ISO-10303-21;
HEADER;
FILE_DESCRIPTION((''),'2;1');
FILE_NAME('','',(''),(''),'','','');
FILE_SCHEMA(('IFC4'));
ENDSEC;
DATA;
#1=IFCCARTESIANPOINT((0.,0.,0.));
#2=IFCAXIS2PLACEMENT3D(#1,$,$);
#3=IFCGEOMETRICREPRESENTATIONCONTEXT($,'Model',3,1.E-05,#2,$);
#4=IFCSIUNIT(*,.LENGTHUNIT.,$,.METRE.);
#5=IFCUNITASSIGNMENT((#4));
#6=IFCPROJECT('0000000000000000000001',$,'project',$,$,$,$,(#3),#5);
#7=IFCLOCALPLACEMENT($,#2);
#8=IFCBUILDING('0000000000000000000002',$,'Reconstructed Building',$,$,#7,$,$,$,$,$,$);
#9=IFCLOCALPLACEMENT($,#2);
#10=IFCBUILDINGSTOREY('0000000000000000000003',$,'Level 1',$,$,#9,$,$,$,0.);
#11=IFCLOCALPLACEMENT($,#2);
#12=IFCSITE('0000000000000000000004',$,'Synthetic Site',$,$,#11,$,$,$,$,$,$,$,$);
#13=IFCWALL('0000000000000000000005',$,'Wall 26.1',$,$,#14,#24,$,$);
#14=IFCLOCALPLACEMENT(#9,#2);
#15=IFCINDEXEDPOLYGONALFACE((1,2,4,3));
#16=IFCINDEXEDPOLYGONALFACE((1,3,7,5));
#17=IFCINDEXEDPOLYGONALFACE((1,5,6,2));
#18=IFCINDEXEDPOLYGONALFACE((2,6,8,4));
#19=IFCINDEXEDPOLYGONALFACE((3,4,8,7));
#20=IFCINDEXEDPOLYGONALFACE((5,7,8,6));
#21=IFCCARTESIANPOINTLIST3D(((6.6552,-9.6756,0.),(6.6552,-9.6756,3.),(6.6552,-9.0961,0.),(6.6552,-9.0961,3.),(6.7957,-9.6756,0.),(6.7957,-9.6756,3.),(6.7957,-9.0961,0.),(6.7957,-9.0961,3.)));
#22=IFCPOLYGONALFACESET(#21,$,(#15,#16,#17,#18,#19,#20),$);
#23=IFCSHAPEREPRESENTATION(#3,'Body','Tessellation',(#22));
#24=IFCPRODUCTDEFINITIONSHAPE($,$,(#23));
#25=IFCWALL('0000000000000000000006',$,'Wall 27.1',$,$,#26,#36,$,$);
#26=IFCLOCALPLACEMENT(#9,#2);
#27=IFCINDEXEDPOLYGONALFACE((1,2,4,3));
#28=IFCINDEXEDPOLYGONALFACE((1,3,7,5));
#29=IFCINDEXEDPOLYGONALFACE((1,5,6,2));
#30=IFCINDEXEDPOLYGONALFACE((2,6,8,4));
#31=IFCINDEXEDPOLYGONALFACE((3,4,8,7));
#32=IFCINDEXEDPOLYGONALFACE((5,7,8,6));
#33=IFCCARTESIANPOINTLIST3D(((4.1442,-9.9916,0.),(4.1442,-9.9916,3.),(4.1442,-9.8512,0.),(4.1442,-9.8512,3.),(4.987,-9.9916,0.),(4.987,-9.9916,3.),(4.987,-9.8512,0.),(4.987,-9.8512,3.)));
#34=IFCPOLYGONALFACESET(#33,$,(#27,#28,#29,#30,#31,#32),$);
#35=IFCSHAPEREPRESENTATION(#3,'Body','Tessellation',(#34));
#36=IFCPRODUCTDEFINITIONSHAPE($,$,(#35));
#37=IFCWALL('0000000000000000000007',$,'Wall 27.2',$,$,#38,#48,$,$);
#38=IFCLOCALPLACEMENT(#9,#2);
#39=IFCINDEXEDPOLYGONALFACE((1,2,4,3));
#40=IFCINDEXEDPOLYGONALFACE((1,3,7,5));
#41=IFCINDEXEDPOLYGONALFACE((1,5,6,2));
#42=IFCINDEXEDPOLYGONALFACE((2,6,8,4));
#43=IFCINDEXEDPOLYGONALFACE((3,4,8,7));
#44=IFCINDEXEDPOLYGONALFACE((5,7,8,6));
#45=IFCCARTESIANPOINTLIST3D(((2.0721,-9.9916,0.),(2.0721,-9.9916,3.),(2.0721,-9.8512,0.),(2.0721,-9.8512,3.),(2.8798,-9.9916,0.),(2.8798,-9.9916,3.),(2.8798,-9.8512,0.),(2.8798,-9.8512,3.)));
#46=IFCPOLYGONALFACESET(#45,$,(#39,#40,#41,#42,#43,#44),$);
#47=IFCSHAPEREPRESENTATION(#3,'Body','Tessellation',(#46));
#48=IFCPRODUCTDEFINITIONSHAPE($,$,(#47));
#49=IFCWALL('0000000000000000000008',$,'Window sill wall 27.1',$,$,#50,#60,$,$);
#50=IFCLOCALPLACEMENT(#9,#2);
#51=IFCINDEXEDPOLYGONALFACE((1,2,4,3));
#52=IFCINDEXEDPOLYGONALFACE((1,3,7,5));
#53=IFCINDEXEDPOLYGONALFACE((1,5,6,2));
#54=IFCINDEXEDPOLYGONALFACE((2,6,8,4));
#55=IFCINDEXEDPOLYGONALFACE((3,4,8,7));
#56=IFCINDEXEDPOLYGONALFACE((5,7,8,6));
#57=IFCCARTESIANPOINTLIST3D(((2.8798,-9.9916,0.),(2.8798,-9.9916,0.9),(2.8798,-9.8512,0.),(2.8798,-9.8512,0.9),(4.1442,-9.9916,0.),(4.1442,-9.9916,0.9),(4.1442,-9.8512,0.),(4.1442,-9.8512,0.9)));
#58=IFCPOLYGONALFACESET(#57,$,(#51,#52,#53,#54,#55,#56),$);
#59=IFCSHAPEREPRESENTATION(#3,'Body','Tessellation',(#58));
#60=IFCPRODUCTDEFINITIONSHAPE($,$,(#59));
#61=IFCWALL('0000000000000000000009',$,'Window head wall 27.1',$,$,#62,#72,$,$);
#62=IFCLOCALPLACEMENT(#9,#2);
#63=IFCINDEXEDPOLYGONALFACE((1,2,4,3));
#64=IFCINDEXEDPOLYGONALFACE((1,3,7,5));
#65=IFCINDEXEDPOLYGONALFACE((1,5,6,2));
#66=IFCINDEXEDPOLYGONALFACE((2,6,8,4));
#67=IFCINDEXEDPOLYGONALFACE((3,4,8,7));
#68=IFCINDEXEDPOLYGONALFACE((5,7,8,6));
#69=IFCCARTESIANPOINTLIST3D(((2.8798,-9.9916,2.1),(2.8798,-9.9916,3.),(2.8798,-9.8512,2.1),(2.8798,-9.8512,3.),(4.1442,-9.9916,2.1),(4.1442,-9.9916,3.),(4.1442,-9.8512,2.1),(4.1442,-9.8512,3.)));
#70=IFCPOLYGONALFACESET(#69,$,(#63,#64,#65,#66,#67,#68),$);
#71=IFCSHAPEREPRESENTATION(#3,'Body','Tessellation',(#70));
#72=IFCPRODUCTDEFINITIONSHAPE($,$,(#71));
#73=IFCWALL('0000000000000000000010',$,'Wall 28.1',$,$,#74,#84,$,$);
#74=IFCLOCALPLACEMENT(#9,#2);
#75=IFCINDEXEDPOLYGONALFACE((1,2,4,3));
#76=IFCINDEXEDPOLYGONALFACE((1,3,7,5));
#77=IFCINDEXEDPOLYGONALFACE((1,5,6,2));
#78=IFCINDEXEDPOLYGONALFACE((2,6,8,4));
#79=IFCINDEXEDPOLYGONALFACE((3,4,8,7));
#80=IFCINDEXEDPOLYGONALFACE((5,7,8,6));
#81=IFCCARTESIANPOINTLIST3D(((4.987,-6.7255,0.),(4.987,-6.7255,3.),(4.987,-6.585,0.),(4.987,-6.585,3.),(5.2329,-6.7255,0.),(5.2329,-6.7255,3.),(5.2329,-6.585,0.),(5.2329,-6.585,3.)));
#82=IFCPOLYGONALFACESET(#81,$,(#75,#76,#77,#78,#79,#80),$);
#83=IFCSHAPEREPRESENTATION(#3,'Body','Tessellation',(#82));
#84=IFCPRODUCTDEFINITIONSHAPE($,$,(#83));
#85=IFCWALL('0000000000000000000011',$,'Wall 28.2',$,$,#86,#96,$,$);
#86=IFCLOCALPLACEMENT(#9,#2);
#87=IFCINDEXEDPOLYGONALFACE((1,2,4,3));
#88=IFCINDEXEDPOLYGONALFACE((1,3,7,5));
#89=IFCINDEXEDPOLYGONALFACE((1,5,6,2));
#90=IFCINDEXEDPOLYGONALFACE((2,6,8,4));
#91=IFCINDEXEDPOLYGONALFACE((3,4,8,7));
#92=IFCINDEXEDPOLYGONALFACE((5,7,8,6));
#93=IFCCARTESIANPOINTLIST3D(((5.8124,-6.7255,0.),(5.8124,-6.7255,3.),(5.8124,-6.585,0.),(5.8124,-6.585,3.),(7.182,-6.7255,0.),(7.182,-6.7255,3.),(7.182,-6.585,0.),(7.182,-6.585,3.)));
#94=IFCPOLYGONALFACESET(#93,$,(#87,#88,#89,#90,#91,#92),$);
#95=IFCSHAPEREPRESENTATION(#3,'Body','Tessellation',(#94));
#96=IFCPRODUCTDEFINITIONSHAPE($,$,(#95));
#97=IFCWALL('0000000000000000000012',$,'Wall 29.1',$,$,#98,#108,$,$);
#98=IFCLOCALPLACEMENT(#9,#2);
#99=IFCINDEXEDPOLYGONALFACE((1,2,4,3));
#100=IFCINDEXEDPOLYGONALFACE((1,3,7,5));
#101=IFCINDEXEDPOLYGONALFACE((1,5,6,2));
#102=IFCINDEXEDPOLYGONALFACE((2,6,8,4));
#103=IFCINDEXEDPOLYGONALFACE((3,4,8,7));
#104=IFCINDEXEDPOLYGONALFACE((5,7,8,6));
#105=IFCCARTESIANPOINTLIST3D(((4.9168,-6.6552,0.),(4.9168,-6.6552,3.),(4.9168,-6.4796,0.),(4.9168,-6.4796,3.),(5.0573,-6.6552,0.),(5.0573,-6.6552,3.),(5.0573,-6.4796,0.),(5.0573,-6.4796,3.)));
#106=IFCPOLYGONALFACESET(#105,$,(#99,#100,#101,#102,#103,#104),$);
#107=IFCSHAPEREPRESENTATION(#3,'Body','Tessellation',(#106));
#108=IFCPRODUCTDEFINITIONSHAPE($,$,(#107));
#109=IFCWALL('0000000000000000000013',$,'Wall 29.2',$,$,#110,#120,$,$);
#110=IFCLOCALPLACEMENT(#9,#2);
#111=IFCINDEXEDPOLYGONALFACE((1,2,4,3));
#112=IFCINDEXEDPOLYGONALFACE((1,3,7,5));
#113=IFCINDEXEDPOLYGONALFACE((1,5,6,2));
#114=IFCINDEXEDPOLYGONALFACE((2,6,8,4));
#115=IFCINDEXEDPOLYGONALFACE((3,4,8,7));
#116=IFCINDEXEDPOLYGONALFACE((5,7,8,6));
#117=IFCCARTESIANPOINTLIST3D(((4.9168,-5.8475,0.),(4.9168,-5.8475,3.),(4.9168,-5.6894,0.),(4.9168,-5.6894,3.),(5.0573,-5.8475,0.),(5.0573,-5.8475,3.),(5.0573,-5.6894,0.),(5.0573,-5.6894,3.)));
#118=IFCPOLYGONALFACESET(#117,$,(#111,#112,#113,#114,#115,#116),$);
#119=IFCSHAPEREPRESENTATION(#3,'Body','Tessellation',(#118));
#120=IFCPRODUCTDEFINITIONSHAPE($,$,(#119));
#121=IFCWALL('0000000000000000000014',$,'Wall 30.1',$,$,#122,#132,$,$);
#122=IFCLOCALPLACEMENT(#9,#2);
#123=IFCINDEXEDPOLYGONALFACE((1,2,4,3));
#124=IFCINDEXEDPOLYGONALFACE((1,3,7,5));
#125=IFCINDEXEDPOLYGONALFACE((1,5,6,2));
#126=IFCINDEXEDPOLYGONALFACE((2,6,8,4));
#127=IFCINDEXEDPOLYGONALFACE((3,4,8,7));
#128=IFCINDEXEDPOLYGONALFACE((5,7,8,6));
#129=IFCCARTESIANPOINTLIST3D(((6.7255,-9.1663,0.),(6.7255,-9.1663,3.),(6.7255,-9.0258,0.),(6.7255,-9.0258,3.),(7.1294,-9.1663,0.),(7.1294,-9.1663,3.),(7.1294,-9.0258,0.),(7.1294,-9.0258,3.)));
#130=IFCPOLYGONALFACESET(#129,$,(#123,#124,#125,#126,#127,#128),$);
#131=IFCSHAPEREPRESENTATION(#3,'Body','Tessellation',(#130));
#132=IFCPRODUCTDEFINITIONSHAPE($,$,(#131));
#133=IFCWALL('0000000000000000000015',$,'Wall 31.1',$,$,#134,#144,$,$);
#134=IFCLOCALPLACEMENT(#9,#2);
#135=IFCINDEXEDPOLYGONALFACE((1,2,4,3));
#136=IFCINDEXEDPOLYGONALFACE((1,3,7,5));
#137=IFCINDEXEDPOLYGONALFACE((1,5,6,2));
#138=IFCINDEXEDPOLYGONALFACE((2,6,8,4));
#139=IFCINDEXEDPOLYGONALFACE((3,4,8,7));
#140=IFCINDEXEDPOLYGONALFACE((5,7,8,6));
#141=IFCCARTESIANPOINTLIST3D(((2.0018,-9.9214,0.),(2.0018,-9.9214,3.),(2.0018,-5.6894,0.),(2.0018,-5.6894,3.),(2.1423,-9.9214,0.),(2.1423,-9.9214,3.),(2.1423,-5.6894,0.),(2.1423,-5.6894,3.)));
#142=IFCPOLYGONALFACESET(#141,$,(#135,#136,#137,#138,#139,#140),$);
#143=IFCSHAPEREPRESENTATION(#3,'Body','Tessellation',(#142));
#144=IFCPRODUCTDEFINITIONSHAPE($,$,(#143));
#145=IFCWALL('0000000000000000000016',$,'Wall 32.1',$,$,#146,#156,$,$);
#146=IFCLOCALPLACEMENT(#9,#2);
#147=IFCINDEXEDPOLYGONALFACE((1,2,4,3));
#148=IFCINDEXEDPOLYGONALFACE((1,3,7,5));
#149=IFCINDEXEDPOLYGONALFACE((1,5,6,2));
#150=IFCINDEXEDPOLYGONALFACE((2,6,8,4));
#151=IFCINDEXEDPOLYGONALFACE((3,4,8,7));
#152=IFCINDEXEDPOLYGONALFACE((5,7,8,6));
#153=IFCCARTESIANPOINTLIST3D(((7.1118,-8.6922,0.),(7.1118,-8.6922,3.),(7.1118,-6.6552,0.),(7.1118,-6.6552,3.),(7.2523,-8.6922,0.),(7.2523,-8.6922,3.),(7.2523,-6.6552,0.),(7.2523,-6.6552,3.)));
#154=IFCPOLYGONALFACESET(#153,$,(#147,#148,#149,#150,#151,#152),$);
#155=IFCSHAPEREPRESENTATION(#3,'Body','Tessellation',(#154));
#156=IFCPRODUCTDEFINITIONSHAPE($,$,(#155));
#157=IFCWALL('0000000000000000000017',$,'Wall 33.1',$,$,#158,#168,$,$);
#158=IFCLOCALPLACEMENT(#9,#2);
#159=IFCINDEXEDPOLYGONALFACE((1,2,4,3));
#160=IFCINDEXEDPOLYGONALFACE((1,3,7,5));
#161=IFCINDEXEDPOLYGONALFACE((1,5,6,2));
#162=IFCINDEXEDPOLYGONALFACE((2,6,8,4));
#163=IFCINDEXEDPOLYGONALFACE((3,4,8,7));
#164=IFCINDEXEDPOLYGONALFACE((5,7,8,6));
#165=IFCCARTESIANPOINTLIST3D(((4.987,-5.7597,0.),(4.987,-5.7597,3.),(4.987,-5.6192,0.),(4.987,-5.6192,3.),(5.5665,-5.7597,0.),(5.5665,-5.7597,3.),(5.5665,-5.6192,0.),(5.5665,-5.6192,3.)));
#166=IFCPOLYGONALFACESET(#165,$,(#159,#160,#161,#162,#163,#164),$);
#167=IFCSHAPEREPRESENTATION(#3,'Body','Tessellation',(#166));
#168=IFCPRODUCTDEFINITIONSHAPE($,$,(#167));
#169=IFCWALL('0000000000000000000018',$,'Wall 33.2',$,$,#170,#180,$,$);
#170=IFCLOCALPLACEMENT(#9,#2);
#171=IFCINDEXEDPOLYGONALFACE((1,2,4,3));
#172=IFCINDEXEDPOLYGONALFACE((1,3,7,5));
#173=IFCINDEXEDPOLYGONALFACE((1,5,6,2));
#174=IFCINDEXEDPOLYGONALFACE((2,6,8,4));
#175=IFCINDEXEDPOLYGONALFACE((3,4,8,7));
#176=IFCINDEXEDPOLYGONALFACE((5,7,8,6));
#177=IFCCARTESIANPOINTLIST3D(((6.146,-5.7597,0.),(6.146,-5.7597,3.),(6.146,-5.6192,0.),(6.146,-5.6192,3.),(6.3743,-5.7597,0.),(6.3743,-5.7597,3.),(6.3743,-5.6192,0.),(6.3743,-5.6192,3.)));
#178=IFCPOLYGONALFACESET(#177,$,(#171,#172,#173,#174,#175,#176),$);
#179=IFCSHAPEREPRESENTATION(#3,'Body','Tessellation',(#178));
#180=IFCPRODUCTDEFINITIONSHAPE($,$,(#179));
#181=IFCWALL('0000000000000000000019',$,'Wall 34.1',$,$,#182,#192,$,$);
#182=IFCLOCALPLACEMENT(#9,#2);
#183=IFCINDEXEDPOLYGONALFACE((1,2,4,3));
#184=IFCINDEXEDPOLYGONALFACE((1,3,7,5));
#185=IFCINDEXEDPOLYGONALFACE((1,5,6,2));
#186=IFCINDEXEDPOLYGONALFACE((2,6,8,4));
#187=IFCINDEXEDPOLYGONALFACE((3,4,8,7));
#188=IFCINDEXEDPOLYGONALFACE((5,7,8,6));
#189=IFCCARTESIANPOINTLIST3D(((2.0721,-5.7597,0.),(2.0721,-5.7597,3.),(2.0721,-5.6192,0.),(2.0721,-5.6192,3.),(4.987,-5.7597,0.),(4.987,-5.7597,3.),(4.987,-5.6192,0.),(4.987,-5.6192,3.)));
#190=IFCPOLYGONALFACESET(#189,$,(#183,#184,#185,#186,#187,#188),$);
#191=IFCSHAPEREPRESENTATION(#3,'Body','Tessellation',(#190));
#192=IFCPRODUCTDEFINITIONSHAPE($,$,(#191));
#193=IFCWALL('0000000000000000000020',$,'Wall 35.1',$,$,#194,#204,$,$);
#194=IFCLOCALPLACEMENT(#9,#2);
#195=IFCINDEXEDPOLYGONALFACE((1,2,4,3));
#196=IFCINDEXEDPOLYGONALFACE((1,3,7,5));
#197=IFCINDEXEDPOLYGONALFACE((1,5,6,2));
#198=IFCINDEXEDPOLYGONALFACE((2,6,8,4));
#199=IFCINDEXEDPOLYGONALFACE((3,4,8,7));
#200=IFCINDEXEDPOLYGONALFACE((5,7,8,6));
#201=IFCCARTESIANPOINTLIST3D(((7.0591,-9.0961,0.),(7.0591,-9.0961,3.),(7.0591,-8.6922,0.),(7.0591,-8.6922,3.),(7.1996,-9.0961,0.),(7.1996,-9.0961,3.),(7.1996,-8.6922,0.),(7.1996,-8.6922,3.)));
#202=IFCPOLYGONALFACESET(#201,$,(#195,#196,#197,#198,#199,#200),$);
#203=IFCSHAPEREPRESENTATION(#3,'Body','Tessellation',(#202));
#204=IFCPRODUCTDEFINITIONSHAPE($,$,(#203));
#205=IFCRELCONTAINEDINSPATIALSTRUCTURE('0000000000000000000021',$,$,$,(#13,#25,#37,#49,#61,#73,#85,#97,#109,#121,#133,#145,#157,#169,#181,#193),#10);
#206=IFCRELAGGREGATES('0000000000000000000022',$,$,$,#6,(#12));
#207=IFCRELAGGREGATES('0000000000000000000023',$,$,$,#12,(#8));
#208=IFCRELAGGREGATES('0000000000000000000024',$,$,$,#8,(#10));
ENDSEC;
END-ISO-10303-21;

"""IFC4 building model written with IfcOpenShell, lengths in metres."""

from ifc_helpers import new_model, si_unit, frame, origin, place, context, project, spatial, polyline, outline, extrude, element, save


model = new_model("IFC4")

# Units and contexts
model_context = context("Model", 3, precision=1e-05, world=origin())
ifc_project = project(units=[si_unit("LENGTHUNIT", "METRE")], contexts=[model_context])

# Site, building, storey
site_placement = place(None, origin())
site = spatial("IfcSite", under=ifc_project, at=site_placement, Name="Synthetic Site")
building_placement = place(None, origin())
building = spatial("IfcBuilding", under=site, at=building_placement, Name="Reconstructed Building")
storey_placement = place(None, origin())
storey = spatial("IfcBuildingStorey", under=building, at=storey_placement, Name="Level 1", Elevation=0.0)

# Walls
wall_1_placement = place(None, origin())
element("IfcWall", 1, at=wall_1_placement, inside=storey, Name="Wall 26.1", context=model_context, shape_type="SweptSolid", body=[
    extrude(outline(polyline([(6.7957, -9.6756), (6.7957, -9.0961), (6.6552, -9.0961), (6.6552, -9.6756), (6.7957, -9.6756)])), frame((0.0, 0.0, 0.0), z_axis=(0.0, 0.0, 1.0)), (0.0, 0.0, 1.0), 3.0),
])
wall_2_placement = place(None, origin())
element("IfcWall", 2, at=wall_2_placement, inside=storey, Name="Wall 27.1", context=model_context, shape_type="SweptSolid", body=[
    extrude(outline(polyline([(4.987, -9.8512), (4.1442, -9.8512), (4.1442, -9.9916), (4.987, -9.9916), (4.987, -9.8512)])), frame((0.0, 0.0, 0.0), z_axis=(0.0, 0.0, 1.0)), (0.0, 0.0, 1.0), 3.0),
])
wall_3_placement = place(None, origin())
element("IfcWall", 3, at=wall_3_placement, inside=storey, Name="Wall 27.2", context=model_context, shape_type="SweptSolid", body=[
    extrude(outline(polyline([(2.8798, -9.8512), (2.0721, -9.8512), (2.0721, -9.9916), (2.8798, -9.9916), (2.8798, -9.8512)])), frame((0.0, 0.0, 0.0), z_axis=(0.0, 0.0, 1.0)), (0.0, 0.0, 1.0), 3.0),
])
wall_4_placement = place(None, origin())
element("IfcWall", 4, at=wall_4_placement, inside=storey, Name="Window sill wall 27.1", context=model_context, shape_type="SweptSolid", body=[
    extrude(outline(polyline([(4.1442, -9.8512), (2.8798, -9.8512), (2.8798, -9.9916), (4.1442, -9.9916), (4.1442, -9.8512)])), frame((0.0, 0.0, 0.0), z_axis=(0.0, 0.0, 1.0)), (0.0, 0.0, 1.0), 0.9),
])
wall_5_placement = place(None, origin())
element("IfcWall", 5, at=wall_5_placement, inside=storey, Name="Window head wall 27.1", context=model_context, shape_type="SweptSolid", body=[
    extrude(outline(polyline([(4.1442, -9.8512), (2.8798, -9.8512), (2.8798, -9.9916), (4.1442, -9.9916), (4.1442, -9.8512)])), frame((0.0, 0.0, 2.1), z_axis=(0.0, 0.0, 1.0)), (0.0, 0.0, 1.0), 0.9),
])
wall_6_placement = place(None, origin())
element("IfcWall", 6, at=wall_6_placement, inside=storey, Name="Wall 28.1", context=model_context, shape_type="SweptSolid", body=[
    extrude(outline(polyline([(4.987, -6.7255), (5.2329, -6.7255), (5.2329, -6.585), (4.987, -6.585), (4.987, -6.7255)])), frame((0.0, 0.0, 0.0), z_axis=(0.0, 0.0, 1.0)), (0.0, 0.0, 1.0), 3.0),
])
wall_7_placement = place(None, origin())
element("IfcWall", 7, at=wall_7_placement, inside=storey, Name="Wall 28.2", context=model_context, shape_type="SweptSolid", body=[
    extrude(outline(polyline([(5.8124, -6.7255), (7.182, -6.7255), (7.182, -6.585), (5.8124, -6.585), (5.8124, -6.7255)])), frame((0.0, 0.0, 0.0), z_axis=(0.0, 0.0, 1.0)), (0.0, 0.0, 1.0), 3.0),
])
wall_8_placement = place(None, origin())
element("IfcWall", 8, at=wall_8_placement, inside=storey, Name="Wall 29.1", context=model_context, shape_type="SweptSolid", body=[
    extrude(outline(polyline([(5.0573, -6.6552), (5.0573, -6.4796), (4.9168, -6.4796), (4.9168, -6.6552), (5.0573, -6.6552)])), frame((0.0, 0.0, 0.0), z_axis=(0.0, 0.0, 1.0)), (0.0, 0.0, 1.0), 3.0),
])
wall_9_placement = place(None, origin())
element("IfcWall", 9, at=wall_9_placement, inside=storey, Name="Wall 29.2", context=model_context, shape_type="SweptSolid", body=[
    extrude(outline(polyline([(5.0573, -5.8475), (5.0573, -5.6894), (4.9168, -5.6894), (4.9168, -5.8475), (5.0573, -5.8475)])), frame((0.0, 0.0, 0.0), z_axis=(0.0, 0.0, 1.0)), (0.0, 0.0, 1.0), 3.0),
])
wall_10_placement = place(None, origin())
element("IfcWall", 10, at=wall_10_placement, inside=storey, Name="Wall 30.1", context=model_context, shape_type="SweptSolid", body=[
    extrude(outline(polyline([(6.7255, -9.1663), (7.1294, -9.1663), (7.1294, -9.0258), (6.7255, -9.0258), (6.7255, -9.1663)])), frame((0.0, 0.0, 0.0), z_axis=(0.0, 0.0, 1.0)), (0.0, 0.0, 1.0), 3.0),
])
wall_11_placement = place(None, origin())
element("IfcWall", 11, at=wall_11_placement, inside=storey, Name="Wall 31.1", context=model_context, shape_type="SweptSolid", body=[
    extrude(outline(polyline([(2.1423, -9.9214), (2.1423, -5.6894), (2.0018, -5.6894), (2.0018, -9.9214), (2.1423, -9.9214)])), frame((0.0, 0.0, 0.0), z_axis=(0.0, 0.0, 1.0)), (0.0, 0.0, 1.0), 3.0),
])
wall_12_placement = place(None, origin())
element("IfcWall", 12, at=wall_12_placement, inside=storey, Name="Wall 32.1", context=model_context, shape_type="SweptSolid", body=[
    extrude(outline(polyline([(7.1118, -6.6552), (7.1118, -8.6922), (7.2523, -8.6922), (7.2523, -6.6552), (7.1118, -6.6552)])), frame((0.0, 0.0, 0.0), z_axis=(0.0, 0.0, 1.0)), (0.0, 0.0, 1.0), 3.0),
])
wall_13_placement = place(None, origin())
element("IfcWall", 13, at=wall_13_placement, inside=storey, Name="Wall 33.1", context=model_context, shape_type="SweptSolid", body=[
    extrude(outline(polyline([(4.987, -5.7597), (5.5665, -5.7597), (5.5665, -5.6192), (4.987, -5.6192), (4.987, -5.7597)])), frame((0.0, 0.0, 0.0), z_axis=(0.0, 0.0, 1.0)), (0.0, 0.0, 1.0), 3.0),
])
wall_14_placement = place(None, origin())
element("IfcWall", 14, at=wall_14_placement, inside=storey, Name="Wall 33.2", context=model_context, shape_type="SweptSolid", body=[
    extrude(outline(polyline([(6.146, -5.7597), (6.3743, -5.7597), (6.3743, -5.6192), (6.146, -5.6192), (6.146, -5.7597)])), frame((0.0, 0.0, 0.0), z_axis=(0.0, 0.0, 1.0)), (0.0, 0.0, 1.0), 3.0),
])
wall_15_placement = place(None, origin())
element("IfcWall", 15, at=wall_15_placement, inside=storey, Name="Wall 34.1", context=model_context, shape_type="SweptSolid", body=[
    extrude(outline(polyline([(4.987, -5.6192), (2.0721, -5.6192), (2.0721, -5.7597), (4.987, -5.7597), (4.987, -5.6192)])), frame((0.0, 0.0, 0.0), z_axis=(0.0, 0.0, 1.0)), (0.0, 0.0, 1.0), 3.0),
])
wall_16_placement = place(None, origin())
element("IfcWall", 16, at=wall_16_placement, inside=storey, Name="Wall 35.1", context=model_context, shape_type="SweptSolid", body=[
    extrude(outline(polyline([(7.1996, -9.0961), (7.1996, -8.6922), (7.0591, -8.6922), (7.0591, -9.0961), (7.1996, -9.0961)])), frame((0.0, 0.0, 0.0), z_axis=(0.0, 0.0, 1.0)), (0.0, 0.0, 1.0), 3.0),
])

save(model, "model.ifc")
